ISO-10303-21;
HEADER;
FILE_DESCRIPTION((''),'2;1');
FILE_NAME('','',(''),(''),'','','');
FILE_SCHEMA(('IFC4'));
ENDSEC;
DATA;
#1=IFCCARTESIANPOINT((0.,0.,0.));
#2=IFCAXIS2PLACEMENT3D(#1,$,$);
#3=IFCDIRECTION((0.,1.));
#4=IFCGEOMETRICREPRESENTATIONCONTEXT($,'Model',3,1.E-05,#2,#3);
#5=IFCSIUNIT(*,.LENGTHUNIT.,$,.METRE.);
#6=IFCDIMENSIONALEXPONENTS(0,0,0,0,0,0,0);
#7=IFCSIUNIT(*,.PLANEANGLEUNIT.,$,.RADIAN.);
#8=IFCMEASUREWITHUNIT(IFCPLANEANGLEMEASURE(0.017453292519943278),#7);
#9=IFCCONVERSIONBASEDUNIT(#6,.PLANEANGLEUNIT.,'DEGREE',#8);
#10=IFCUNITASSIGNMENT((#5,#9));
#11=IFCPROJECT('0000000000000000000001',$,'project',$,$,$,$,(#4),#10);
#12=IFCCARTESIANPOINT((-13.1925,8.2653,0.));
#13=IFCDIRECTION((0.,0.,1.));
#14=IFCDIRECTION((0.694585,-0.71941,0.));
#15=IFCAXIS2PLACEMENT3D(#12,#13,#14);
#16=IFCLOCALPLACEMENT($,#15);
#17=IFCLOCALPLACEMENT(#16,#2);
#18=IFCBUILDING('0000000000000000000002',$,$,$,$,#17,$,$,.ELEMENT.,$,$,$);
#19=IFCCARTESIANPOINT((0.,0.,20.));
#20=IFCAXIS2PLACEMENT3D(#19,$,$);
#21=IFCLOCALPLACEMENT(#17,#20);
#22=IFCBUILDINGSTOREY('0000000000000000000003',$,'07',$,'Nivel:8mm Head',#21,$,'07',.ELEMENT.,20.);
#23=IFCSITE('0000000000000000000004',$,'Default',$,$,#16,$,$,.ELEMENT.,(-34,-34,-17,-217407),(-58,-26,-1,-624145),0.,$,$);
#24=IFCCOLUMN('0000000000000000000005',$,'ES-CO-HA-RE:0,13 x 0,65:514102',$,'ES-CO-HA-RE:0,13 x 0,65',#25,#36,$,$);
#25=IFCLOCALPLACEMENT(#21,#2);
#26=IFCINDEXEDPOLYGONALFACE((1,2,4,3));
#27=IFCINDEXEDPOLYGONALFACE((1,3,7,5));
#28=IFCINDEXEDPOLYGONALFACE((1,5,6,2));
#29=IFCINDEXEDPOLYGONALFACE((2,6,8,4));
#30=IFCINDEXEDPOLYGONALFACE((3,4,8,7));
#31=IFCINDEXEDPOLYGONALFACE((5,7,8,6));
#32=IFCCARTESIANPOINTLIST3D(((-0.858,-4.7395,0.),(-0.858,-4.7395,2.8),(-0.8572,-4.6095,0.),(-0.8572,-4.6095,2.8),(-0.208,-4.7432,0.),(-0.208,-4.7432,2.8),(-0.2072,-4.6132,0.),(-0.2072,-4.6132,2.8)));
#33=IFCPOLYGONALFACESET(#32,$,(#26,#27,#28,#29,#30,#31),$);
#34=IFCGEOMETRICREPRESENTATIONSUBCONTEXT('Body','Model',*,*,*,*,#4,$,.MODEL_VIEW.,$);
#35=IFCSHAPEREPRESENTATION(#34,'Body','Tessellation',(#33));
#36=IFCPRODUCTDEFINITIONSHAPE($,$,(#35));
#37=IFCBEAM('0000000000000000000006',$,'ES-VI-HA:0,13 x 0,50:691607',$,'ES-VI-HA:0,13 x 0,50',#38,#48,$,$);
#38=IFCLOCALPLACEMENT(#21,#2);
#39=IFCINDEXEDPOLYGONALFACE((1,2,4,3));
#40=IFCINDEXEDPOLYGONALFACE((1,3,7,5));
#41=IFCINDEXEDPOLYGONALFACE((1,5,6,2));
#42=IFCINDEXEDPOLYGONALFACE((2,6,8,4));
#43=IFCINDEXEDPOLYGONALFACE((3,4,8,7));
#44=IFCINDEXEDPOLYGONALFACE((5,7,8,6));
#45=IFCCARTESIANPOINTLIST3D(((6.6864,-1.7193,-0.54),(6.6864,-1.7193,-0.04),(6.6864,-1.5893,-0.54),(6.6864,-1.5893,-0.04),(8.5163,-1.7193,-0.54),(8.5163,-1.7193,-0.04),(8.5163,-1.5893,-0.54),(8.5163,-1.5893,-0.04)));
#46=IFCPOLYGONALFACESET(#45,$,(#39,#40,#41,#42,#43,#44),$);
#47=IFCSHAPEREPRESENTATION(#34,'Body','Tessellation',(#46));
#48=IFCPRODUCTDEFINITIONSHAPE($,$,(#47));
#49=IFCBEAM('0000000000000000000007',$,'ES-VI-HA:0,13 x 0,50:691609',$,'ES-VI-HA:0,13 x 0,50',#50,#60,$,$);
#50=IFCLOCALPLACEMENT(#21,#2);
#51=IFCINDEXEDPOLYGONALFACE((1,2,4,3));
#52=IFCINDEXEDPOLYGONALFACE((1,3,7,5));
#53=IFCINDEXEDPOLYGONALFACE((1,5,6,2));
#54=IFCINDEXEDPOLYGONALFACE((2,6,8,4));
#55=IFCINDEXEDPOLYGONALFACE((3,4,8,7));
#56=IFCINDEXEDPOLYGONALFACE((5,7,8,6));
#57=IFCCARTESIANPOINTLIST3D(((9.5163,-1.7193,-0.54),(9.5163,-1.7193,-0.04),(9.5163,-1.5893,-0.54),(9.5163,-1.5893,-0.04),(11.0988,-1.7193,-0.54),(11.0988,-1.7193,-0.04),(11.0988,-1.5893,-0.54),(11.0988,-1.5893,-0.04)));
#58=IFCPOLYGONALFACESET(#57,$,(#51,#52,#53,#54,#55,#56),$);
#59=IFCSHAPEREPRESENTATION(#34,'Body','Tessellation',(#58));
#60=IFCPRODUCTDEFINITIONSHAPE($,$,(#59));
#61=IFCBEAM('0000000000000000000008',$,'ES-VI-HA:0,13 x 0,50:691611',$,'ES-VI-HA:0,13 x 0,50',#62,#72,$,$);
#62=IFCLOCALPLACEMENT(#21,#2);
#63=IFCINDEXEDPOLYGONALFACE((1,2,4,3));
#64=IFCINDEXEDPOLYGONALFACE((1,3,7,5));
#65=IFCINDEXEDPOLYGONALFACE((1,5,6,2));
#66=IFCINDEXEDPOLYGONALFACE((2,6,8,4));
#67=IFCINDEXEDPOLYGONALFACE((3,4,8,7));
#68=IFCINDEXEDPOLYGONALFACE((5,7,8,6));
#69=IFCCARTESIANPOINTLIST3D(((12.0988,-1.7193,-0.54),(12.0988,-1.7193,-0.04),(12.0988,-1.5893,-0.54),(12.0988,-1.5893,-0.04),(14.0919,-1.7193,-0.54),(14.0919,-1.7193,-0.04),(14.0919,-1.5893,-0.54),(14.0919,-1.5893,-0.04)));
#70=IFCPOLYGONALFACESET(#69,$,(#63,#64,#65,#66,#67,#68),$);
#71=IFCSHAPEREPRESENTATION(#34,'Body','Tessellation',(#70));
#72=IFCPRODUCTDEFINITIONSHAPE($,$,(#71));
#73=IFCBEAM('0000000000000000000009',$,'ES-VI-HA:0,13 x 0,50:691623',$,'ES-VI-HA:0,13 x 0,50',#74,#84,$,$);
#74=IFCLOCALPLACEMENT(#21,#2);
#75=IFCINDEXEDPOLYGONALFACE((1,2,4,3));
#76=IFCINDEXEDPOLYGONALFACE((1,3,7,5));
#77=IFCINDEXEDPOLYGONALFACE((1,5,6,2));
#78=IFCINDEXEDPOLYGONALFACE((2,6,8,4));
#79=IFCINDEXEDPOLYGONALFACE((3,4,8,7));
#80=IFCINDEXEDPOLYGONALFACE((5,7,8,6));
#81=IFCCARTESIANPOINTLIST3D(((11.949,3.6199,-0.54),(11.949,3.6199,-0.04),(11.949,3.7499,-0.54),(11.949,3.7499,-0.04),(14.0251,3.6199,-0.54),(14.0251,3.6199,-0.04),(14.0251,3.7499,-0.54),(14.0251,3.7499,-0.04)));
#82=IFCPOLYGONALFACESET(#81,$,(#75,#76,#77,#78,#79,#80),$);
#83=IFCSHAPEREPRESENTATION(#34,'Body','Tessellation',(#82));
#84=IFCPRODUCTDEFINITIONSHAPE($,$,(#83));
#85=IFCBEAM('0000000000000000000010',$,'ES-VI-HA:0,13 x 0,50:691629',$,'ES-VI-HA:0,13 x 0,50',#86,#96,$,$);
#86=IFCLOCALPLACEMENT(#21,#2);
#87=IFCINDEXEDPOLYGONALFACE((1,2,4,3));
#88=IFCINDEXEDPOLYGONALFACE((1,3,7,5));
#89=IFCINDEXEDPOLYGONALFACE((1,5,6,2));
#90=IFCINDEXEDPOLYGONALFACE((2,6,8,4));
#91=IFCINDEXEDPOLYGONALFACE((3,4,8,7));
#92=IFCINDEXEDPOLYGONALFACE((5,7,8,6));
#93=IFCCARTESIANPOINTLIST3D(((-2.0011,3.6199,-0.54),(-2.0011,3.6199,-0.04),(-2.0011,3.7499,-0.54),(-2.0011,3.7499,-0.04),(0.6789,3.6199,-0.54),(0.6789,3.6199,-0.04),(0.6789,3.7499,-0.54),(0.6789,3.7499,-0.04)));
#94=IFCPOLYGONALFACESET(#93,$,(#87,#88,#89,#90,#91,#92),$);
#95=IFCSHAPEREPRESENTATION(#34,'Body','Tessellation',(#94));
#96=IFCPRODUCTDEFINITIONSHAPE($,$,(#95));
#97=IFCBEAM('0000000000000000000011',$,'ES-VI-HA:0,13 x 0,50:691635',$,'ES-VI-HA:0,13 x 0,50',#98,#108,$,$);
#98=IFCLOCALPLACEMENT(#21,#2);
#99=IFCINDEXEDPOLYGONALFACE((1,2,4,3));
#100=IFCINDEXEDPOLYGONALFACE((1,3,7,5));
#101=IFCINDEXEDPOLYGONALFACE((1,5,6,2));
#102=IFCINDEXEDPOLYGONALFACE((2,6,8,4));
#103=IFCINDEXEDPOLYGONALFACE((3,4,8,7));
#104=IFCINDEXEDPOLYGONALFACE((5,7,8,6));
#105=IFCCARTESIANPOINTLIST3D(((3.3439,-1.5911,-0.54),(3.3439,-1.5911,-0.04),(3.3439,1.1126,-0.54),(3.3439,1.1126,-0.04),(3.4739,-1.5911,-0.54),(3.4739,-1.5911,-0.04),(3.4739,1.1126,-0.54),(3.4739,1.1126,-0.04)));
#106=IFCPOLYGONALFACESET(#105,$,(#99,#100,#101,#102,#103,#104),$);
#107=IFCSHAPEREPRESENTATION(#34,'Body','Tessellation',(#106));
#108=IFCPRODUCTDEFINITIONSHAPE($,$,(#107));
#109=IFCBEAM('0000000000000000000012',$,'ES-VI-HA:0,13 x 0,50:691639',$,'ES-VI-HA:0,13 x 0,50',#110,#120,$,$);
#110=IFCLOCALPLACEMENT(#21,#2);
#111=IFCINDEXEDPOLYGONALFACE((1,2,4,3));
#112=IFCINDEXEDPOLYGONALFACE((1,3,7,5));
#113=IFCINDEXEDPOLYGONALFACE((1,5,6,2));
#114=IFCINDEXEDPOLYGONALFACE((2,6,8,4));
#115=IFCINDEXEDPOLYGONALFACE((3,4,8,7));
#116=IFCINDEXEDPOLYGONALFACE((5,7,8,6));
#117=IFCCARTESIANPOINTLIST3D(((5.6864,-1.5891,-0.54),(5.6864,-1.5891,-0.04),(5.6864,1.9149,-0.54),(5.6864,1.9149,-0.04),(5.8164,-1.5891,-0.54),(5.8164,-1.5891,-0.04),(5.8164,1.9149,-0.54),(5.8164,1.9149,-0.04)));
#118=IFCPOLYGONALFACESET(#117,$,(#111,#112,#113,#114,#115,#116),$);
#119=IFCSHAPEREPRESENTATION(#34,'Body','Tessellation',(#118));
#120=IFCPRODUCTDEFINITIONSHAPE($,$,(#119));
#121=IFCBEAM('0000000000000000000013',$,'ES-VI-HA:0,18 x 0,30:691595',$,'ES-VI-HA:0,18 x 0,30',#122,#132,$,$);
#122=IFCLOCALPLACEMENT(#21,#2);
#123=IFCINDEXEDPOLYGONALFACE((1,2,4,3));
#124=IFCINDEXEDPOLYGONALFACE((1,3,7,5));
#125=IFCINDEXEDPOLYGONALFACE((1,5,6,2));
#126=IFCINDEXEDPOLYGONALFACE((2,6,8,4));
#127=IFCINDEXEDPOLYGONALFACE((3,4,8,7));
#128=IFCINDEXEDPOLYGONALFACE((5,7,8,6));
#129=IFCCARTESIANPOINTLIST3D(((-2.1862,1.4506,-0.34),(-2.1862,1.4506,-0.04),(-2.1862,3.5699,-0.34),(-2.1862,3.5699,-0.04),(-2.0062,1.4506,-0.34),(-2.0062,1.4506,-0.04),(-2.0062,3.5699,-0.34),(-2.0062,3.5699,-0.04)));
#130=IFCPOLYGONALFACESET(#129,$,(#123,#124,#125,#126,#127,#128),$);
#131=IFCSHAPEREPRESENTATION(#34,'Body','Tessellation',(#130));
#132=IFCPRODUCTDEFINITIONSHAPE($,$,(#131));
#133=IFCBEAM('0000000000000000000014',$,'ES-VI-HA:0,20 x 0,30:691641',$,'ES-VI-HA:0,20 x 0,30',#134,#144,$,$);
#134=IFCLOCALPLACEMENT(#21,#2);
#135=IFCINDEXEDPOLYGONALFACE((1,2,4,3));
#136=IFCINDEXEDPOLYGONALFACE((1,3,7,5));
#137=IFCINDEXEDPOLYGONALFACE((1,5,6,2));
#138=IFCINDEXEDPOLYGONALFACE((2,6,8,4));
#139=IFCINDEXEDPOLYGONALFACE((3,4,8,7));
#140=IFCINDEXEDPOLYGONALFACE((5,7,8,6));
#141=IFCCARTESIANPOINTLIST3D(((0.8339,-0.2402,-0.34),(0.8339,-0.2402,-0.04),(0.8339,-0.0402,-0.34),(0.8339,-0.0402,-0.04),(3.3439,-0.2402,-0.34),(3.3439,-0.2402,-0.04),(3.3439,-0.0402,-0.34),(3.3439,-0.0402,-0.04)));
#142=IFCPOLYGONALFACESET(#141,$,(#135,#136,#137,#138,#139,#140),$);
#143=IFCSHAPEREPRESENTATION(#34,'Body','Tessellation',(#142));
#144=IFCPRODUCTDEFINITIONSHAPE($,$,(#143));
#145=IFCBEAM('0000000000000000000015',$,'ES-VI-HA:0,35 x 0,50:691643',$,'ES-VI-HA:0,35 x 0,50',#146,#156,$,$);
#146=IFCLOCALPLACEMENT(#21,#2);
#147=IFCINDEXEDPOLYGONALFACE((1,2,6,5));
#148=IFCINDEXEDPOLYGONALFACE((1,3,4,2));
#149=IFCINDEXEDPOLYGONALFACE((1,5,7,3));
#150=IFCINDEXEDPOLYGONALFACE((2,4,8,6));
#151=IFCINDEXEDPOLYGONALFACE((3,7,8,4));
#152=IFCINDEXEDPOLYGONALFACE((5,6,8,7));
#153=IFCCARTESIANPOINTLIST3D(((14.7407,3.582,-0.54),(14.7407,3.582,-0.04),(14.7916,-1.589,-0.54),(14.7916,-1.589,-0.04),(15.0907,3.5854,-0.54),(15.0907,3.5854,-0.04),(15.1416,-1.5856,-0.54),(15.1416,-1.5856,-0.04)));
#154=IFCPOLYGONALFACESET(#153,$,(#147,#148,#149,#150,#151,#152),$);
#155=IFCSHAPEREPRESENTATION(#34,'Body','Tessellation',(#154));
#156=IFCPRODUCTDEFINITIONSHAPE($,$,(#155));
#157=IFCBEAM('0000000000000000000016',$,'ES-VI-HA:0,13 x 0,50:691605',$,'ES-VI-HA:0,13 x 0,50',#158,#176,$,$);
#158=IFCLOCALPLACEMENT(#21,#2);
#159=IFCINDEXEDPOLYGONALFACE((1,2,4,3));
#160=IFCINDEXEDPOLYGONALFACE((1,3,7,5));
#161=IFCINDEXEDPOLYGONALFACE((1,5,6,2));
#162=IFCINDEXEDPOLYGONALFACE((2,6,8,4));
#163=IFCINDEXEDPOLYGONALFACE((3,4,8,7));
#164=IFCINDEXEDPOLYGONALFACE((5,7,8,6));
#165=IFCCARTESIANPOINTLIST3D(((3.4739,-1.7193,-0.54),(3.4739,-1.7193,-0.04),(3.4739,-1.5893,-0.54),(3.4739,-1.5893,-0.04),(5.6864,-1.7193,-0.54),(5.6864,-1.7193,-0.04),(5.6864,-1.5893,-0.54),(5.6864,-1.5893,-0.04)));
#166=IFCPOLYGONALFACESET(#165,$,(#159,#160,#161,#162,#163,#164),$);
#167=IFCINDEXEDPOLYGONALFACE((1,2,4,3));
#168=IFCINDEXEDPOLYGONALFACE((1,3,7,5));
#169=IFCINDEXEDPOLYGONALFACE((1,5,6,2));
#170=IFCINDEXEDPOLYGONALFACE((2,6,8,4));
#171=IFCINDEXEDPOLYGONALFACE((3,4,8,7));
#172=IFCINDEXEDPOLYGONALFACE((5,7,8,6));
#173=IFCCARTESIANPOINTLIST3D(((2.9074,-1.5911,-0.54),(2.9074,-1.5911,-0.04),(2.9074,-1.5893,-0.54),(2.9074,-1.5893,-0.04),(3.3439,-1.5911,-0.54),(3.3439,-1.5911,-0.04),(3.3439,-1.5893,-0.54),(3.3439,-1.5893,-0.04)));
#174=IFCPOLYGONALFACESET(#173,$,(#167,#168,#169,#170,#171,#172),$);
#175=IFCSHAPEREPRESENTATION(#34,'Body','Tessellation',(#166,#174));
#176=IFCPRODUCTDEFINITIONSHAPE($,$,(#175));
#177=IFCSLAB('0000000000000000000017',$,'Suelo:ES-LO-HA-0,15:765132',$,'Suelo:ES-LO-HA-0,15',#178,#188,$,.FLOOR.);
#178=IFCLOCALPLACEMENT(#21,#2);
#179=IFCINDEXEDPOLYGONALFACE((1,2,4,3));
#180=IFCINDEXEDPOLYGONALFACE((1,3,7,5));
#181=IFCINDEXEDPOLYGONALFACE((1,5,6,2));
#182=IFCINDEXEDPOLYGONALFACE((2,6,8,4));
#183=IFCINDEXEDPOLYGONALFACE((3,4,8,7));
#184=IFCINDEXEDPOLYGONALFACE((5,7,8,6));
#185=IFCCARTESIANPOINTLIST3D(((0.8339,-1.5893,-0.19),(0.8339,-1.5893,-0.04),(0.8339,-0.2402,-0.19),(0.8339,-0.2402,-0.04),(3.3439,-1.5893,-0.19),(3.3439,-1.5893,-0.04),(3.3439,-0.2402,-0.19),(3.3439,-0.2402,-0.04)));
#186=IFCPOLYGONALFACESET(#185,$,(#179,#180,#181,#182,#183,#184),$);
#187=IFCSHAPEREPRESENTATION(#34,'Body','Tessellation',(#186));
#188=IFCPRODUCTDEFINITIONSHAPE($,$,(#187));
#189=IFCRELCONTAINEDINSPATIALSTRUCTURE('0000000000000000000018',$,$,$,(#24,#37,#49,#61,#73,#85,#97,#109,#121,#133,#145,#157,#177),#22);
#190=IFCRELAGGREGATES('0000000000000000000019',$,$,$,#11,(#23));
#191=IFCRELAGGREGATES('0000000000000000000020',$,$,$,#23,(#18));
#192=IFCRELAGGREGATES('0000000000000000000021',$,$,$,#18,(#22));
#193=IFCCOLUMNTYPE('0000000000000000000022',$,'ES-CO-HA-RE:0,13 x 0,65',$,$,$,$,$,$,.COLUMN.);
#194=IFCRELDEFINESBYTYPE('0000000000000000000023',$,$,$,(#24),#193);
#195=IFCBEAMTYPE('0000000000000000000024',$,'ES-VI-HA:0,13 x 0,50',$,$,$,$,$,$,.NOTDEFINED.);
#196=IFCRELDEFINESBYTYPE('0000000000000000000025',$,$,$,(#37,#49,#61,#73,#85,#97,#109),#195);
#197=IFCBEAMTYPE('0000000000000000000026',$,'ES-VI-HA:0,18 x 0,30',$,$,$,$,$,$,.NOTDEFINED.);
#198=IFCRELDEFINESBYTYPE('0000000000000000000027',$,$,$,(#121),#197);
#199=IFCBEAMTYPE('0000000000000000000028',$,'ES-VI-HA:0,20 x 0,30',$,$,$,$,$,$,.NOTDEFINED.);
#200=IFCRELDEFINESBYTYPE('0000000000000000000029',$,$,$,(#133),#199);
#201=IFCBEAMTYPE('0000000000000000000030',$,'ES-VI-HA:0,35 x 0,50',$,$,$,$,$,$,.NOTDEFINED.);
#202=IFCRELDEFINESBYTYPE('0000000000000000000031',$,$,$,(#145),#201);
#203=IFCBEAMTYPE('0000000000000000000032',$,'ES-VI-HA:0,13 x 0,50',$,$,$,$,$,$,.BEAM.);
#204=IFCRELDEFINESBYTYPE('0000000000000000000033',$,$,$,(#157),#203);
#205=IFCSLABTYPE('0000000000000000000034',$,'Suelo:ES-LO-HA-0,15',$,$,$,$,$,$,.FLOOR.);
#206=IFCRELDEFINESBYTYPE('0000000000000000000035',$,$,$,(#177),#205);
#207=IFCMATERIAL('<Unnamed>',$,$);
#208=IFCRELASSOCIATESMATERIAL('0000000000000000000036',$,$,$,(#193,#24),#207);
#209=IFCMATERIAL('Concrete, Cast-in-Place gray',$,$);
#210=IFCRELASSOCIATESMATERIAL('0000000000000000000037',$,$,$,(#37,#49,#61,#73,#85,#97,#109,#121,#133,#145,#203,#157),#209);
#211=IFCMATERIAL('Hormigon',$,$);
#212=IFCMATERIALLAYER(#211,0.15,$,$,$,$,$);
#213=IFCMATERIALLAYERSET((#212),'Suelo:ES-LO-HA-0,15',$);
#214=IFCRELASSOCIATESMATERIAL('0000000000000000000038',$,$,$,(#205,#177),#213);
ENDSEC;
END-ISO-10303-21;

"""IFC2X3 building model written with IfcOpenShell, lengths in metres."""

from ifc_helpers import new_model, entity, si_unit, converted_unit, direction, frame, frame_2d, origin, origin_2d_with_axis, place, context, subcontext, project, spatial, rectangle, extrude, source, transform, mapped, material, layer, layer_set, layer_usage, type_object, type_shapes, element, save


model = new_model("IFC2X3")

# Units and contexts
model_context = context("Model", 3, precision=1e-05, world=origin(), true_north=direction((0.0, 1.0)))
body_context = subcontext(model_context, "Body", "Model", "MODEL_VIEW")
ifc_project = project(units=[si_unit("LENGTHUNIT", "METRE"), converted_unit("PLANEANGLEUNIT", "DEGREE", entity("IfcPlaneAngleMeasure", 0.017453292519943278), si_unit("PLANEANGLEUNIT", "RADIAN"), dimensions=[0, 0, 0, 0, 0, 0, 0])], contexts=[model_context])

# Site, building, storey
site_placement = place(None, frame((-13.1925, 8.2653, 0.0), z_axis=(0.0, 0.0, 1.0), x_axis=(0.694585, -0.71941, 0.0)))
site = spatial("IfcSite", under=ifc_project, at=site_placement, Name="Default", CompositionType="ELEMENT", RefLatitude=(-34, -34, -17, -217407), RefLongitude=(-58, -26, -1, -624145), RefElevation=0.0)
building_placement = place(site_placement, origin())
building = spatial("IfcBuilding", under=site, at=building_placement, CompositionType="ELEMENT")
storey_placement = place(building_placement, frame((0.0, 0.0, 20.0)))
storey = spatial("IfcBuildingStorey", under=building, at=storey_placement, Name="07", ObjectType="Nivel:8mm Head", LongName="07", CompositionType="ELEMENT", Elevation=20.0)

# Column
ifc_material_1 = material(Name="<Unnamed>")
column_type_1 = type_object("IfcColumnType", Name="ES-CO-HA-RE:0,13 x 0,65", PredefinedType="COLUMN", material=ifc_material_1)
shared_shape_1 = source(origin(), body_context, "Body", "SweptSolid", [
    extrude(rectangle(XDim=0.65, YDim=0.13, at=frame_2d((0.0, 0.0), x_axis=(1.0, 0.0))), frame((-0.5326, -4.6764, 20.0), z_axis=(0.0, 0.0, 1.0), x_axis=(-0.999984, 0.005619, 0.0)), (0.0, 0.0, 1.0), 2.8),
])
type_shapes(column_type_1, [shared_shape_1])
column_1_placement = place(storey_placement, frame((0.0, 0.0, -20.0)))
element("IfcColumn", 1, at=column_1_placement, inside=storey, type_object=column_type_1, material=ifc_material_1, Name="ES-CO-HA-RE:0,13 x 0,65:514102", ObjectType="ES-CO-HA-RE:0,13 x 0,65", context=body_context, shape_type="MappedRepresentation", body=[
    mapped(shared_shape_1, transform((0.0, 0.0, 0.0), scale=1.0)),
])

# Beams
ifc_material_2 = material(Name="Concrete, Cast-in-Place gray")
beam_type_1 = type_object("IfcBeamType", Name="ES-VI-HA:0,13 x 0,50", PredefinedType="NOTDEFINED")
beam_1_placement = place(storey_placement, frame((5.7373, -1.6543, -0.04)))
element("IfcBeam", 2, at=beam_1_placement, inside=storey, type_object=beam_type_1, material=ifc_material_2, Name="ES-VI-HA:0,13 x 0,50:691607", ObjectType="ES-VI-HA:0,13 x 0,50", context=body_context, shape_type="SweptSolid", body=[
    extrude(rectangle(XDim=0.5, YDim=0.13, at=frame_2d((0.0, 0.0), x_axis=(1.0, 0.0))), frame((0.9491, 0.0, -0.25), z_axis=(1.0, 0.0, 0.0), x_axis=(0.0, 0.0, -1.0)), (0.0, 0.0, 1.0), 1.8299),
])
beam_2_placement = place(storey_placement, frame((8.3198, -1.6543, -0.04)))
element("IfcBeam", 3, at=beam_2_placement, inside=storey, type_object=beam_type_1, material=ifc_material_2, Name="ES-VI-HA:0,13 x 0,50:691609", ObjectType="ES-VI-HA:0,13 x 0,50", context=body_context, shape_type="SweptSolid", body=[
    extrude(rectangle(XDim=0.5, YDim=0.13, at=frame_2d((0.0, 0.0), x_axis=(1.0, 0.0))), frame((1.1965, 0.0, -0.25), z_axis=(1.0, 0.0, 0.0), x_axis=(0.0, 0.0, -1.0)), (0.0, 0.0, 1.0), 1.5825),
])
beam_3_placement = place(storey_placement, frame((11.3129, -1.6543, -0.04)))
element("IfcBeam", 4, at=beam_3_placement, inside=storey, type_object=beam_type_1, material=ifc_material_2, Name="ES-VI-HA:0,13 x 0,50:691611", ObjectType="ES-VI-HA:0,13 x 0,50", context=body_context, shape_type="SweptSolid", body=[
    extrude(rectangle(XDim=0.5, YDim=0.13, at=frame_2d((0.0, 0.0), x_axis=(1.0, 0.0))), frame((0.7858, 0.0, -0.25), z_axis=(1.0, 0.0, 0.0), x_axis=(0.0, 0.0, -1.0)), (0.0, 0.0, 1.0), 1.9932),
])
beam_4_placement = place(storey_placement, frame((11.624, 3.6849, -0.04)))
element("IfcBeam", 5, at=beam_4_placement, inside=storey, type_object=beam_type_1, material=ifc_material_2, Name="ES-VI-HA:0,13 x 0,50:691623", ObjectType="ES-VI-HA:0,13 x 0,50", context=body_context, shape_type="SweptSolid", body=[
    extrude(rectangle(XDim=0.5, YDim=0.13, at=frame_2d((0.0, 0.0), x_axis=(1.0, 0.0))), frame((0.325, 0.0, -0.25), z_axis=(1.0, 0.0, 0.0), x_axis=(0.0, 0.0, -1.0)), (0.0, 0.0, 1.0), 2.0761),
])
beam_5_placement = place(storey_placement, frame((-2.0011, 3.6849, -0.04)))
element("IfcBeam", 6, at=beam_5_placement, inside=storey, type_object=beam_type_1, material=ifc_material_2, Name="ES-VI-HA:0,13 x 0,50:691629", ObjectType="ES-VI-HA:0,13 x 0,50", context=body_context, shape_type="SweptSolid", body=[
    extrude(rectangle(XDim=0.5, YDim=0.13, at=frame_2d((0.0, 0.0), x_axis=(1.0, 0.0))), frame((0.0, 0.0, -0.25), z_axis=(1.0, 0.0, 0.0), x_axis=(0.0, 0.0, -1.0)), (0.0, 0.0, 1.0), 2.68),
])
beam_6_placement = place(storey_placement, frame((3.4089, -1.5916, -0.04), z_axis=(0.0, 0.0, 1.0), x_axis=(0.0, 1.0, 0.0)))
element("IfcBeam", 7, at=beam_6_placement, inside=storey, type_object=beam_type_1, material=ifc_material_2, Name="ES-VI-HA:0,13 x 0,50:691635", ObjectType="ES-VI-HA:0,13 x 0,50", context=body_context, shape_type="SweptSolid", body=[
    extrude(rectangle(XDim=0.5, YDim=0.13, at=frame_2d((0.0, 0.0), x_axis=(1.0, 0.0))), frame((0.0005, 0.0, -0.25), z_axis=(1.0, 0.0, 0.0), x_axis=(0.0, 0.0, -1.0)), (0.0, 0.0, 1.0), 2.7037),
])
beam_7_placement = place(storey_placement, frame((5.7514, -1.5891, -0.04), z_axis=(0.0, 0.0, 1.0), x_axis=(0.0, 1.0, 0.0)))
element("IfcBeam", 8, at=beam_7_placement, inside=storey, type_object=beam_type_1, material=ifc_material_2, Name="ES-VI-HA:0,13 x 0,50:691639", ObjectType="ES-VI-HA:0,13 x 0,50", context=body_context, shape_type="SweptSolid", body=[
    extrude(rectangle(XDim=0.5, YDim=0.13, at=frame_2d((0.0, 0.0), x_axis=(1.0, 0.0))), frame((0.0, 0.0, -0.25), z_axis=(1.0, 0.0, 0.0), x_axis=(0.0, 0.0, -1.0)), (0.0, 0.0, 1.0), 3.5039),
])
beam_type_2 = type_object("IfcBeamType", Name="ES-VI-HA:0,18 x 0,30", PredefinedType="NOTDEFINED")
beam_8_placement = place(storey_placement, frame((-2.0962, 3.5699, -0.04), z_axis=(0.0, 0.0, 1.0), x_axis=(0.0, -1.0, 0.0)))
element("IfcBeam", 9, at=beam_8_placement, inside=storey, type_object=beam_type_2, material=ifc_material_2, Name="ES-VI-HA:0,18 x 0,30:691595", ObjectType="ES-VI-HA:0,18 x 0,30", context=body_context, shape_type="SweptSolid", body=[
    extrude(rectangle(XDim=0.3, YDim=0.18, at=origin_2d_with_axis()), frame((0.0, 0.0, -0.15), z_axis=(1.0, 0.0, 0.0), x_axis=(0.0, 0.0, -1.0)), (0.0, 0.0, 1.0), 2.1193),
])
beam_type_3 = type_object("IfcBeamType", Name="ES-VI-HA:0,20 x 0,30", PredefinedType="NOTDEFINED")
beam_9_placement = place(storey_placement, frame((0.7589, -0.1402, -0.04)))
element("IfcBeam", 10, at=beam_9_placement, inside=storey, type_object=beam_type_3, material=ifc_material_2, Name="ES-VI-HA:0,20 x 0,30:691641", ObjectType="ES-VI-HA:0,20 x 0,30", context=body_context, shape_type="SweptSolid", body=[
    extrude(rectangle(XDim=0.3, YDim=0.2, at=frame_2d((0.0, 0.0), x_axis=(1.0, 0.0))), frame((0.075, 0.0, -0.15), z_axis=(1.0, 0.0, 0.0), x_axis=(0.0, 0.0, -1.0)), (0.0, 0.0, 1.0), 2.51),
])
beam_type_4 = type_object("IfcBeamType", Name="ES-VI-HA:0,35 x 0,50", PredefinedType="NOTDEFINED")
beam_10_placement = place(storey_placement, frame((14.9158, 3.5724, -0.04), z_axis=(0.0, 0.0, 1.0), x_axis=(0.009844, -0.999952, 0.0)))
element("IfcBeam", 11, at=beam_10_placement, inside=storey, type_object=beam_type_4, material=ifc_material_2, Name="ES-VI-HA:0,35 x 0,50:691643", ObjectType="ES-VI-HA:0,35 x 0,50", context=body_context, shape_type="SweptSolid", body=[
    extrude(rectangle(XDim=0.5, YDim=0.35, at=frame_2d((0.0, 0.0), x_axis=(1.0, 0.0))), frame((-0.0113, 0.0, -0.25), z_axis=(1.0, 0.0, 0.0), x_axis=(0.0, 0.0, -1.0)), (0.0, 0.0, 1.0), 5.1713),
])
beam_type_5 = type_object("IfcBeamType", Name="ES-VI-HA:0,13 x 0,50", PredefinedType="BEAM", material=ifc_material_2)
shared_shape_2 = source(origin(), body_context, "Body", "SweptSolid", [
    extrude(rectangle(XDim=0.5, YDim=0.13, at=frame_2d((0.0, 0.0), x_axis=(1.0, 0.0))), frame((3.4739, -1.6543, 19.71), z_axis=(1.0, 0.0, 0.0), x_axis=(0.0, 0.0, -1.0)), (0.0, 0.0, 1.0), 2.2125),
    extrude(rectangle(XDim=0.5, YDim=0.0018, at=frame_2d((0.0, 0.0), x_axis=(1.0, 0.0))), frame((2.9074, -1.5902, 19.71), z_axis=(1.0, 0.0, 0.0), x_axis=(0.0, 0.0, -1.0)), (0.0, 0.0, 1.0), 0.4365),
])
type_shapes(beam_type_5, [shared_shape_2])
beam_11_placement = place(storey_placement, frame((0.0, 0.0, -20.0)))
element("IfcBeam", 12, at=beam_11_placement, inside=storey, type_object=beam_type_5, material=ifc_material_2, Name="ES-VI-HA:0,13 x 0,50:691605", ObjectType="ES-VI-HA:0,13 x 0,50", context=body_context, shape_type="MappedRepresentation", body=[
    mapped(shared_shape_2, transform((0.0, 0.0, 0.0), scale=1.0)),
])

# Slab
ifc_material_3 = material(Name="Hormigon")
ifc_layer_1 = layer(ifc_material_3, 0.15)
ifc_layer_set_1 = layer_set([ifc_layer_1], Name="Suelo:ES-LO-HA-0,15")
ifc_layer_usage_1 = layer_usage(ifc_layer_set_1, "AXIS3", "POSITIVE", 0.0)
slab_type_1 = type_object("IfcSlabType", Name="Suelo:ES-LO-HA-0,15", PredefinedType="FLOOR", material=ifc_layer_set_1)
slab_1_placement = place(storey_placement, origin())
element("IfcSlab", 13, at=slab_1_placement, inside=storey, type_object=slab_type_1, material=ifc_layer_usage_1, Name="Suelo:ES-LO-HA-0,15:765132", ObjectType="Suelo:ES-LO-HA-0,15", PredefinedType="FLOOR", context=body_context, shape_type="SweptSolid", body=[
    extrude(rectangle(XDim=1.3491, YDim=2.51, at=origin_2d_with_axis()), frame((2.0889, -0.9147, -0.04), z_axis=(0.0, 0.0, -1.0), x_axis=(0.0, 1.0, 0.0)), (0.0, 0.0, 1.0), 0.15),
])

save(model, "model.ifc")
